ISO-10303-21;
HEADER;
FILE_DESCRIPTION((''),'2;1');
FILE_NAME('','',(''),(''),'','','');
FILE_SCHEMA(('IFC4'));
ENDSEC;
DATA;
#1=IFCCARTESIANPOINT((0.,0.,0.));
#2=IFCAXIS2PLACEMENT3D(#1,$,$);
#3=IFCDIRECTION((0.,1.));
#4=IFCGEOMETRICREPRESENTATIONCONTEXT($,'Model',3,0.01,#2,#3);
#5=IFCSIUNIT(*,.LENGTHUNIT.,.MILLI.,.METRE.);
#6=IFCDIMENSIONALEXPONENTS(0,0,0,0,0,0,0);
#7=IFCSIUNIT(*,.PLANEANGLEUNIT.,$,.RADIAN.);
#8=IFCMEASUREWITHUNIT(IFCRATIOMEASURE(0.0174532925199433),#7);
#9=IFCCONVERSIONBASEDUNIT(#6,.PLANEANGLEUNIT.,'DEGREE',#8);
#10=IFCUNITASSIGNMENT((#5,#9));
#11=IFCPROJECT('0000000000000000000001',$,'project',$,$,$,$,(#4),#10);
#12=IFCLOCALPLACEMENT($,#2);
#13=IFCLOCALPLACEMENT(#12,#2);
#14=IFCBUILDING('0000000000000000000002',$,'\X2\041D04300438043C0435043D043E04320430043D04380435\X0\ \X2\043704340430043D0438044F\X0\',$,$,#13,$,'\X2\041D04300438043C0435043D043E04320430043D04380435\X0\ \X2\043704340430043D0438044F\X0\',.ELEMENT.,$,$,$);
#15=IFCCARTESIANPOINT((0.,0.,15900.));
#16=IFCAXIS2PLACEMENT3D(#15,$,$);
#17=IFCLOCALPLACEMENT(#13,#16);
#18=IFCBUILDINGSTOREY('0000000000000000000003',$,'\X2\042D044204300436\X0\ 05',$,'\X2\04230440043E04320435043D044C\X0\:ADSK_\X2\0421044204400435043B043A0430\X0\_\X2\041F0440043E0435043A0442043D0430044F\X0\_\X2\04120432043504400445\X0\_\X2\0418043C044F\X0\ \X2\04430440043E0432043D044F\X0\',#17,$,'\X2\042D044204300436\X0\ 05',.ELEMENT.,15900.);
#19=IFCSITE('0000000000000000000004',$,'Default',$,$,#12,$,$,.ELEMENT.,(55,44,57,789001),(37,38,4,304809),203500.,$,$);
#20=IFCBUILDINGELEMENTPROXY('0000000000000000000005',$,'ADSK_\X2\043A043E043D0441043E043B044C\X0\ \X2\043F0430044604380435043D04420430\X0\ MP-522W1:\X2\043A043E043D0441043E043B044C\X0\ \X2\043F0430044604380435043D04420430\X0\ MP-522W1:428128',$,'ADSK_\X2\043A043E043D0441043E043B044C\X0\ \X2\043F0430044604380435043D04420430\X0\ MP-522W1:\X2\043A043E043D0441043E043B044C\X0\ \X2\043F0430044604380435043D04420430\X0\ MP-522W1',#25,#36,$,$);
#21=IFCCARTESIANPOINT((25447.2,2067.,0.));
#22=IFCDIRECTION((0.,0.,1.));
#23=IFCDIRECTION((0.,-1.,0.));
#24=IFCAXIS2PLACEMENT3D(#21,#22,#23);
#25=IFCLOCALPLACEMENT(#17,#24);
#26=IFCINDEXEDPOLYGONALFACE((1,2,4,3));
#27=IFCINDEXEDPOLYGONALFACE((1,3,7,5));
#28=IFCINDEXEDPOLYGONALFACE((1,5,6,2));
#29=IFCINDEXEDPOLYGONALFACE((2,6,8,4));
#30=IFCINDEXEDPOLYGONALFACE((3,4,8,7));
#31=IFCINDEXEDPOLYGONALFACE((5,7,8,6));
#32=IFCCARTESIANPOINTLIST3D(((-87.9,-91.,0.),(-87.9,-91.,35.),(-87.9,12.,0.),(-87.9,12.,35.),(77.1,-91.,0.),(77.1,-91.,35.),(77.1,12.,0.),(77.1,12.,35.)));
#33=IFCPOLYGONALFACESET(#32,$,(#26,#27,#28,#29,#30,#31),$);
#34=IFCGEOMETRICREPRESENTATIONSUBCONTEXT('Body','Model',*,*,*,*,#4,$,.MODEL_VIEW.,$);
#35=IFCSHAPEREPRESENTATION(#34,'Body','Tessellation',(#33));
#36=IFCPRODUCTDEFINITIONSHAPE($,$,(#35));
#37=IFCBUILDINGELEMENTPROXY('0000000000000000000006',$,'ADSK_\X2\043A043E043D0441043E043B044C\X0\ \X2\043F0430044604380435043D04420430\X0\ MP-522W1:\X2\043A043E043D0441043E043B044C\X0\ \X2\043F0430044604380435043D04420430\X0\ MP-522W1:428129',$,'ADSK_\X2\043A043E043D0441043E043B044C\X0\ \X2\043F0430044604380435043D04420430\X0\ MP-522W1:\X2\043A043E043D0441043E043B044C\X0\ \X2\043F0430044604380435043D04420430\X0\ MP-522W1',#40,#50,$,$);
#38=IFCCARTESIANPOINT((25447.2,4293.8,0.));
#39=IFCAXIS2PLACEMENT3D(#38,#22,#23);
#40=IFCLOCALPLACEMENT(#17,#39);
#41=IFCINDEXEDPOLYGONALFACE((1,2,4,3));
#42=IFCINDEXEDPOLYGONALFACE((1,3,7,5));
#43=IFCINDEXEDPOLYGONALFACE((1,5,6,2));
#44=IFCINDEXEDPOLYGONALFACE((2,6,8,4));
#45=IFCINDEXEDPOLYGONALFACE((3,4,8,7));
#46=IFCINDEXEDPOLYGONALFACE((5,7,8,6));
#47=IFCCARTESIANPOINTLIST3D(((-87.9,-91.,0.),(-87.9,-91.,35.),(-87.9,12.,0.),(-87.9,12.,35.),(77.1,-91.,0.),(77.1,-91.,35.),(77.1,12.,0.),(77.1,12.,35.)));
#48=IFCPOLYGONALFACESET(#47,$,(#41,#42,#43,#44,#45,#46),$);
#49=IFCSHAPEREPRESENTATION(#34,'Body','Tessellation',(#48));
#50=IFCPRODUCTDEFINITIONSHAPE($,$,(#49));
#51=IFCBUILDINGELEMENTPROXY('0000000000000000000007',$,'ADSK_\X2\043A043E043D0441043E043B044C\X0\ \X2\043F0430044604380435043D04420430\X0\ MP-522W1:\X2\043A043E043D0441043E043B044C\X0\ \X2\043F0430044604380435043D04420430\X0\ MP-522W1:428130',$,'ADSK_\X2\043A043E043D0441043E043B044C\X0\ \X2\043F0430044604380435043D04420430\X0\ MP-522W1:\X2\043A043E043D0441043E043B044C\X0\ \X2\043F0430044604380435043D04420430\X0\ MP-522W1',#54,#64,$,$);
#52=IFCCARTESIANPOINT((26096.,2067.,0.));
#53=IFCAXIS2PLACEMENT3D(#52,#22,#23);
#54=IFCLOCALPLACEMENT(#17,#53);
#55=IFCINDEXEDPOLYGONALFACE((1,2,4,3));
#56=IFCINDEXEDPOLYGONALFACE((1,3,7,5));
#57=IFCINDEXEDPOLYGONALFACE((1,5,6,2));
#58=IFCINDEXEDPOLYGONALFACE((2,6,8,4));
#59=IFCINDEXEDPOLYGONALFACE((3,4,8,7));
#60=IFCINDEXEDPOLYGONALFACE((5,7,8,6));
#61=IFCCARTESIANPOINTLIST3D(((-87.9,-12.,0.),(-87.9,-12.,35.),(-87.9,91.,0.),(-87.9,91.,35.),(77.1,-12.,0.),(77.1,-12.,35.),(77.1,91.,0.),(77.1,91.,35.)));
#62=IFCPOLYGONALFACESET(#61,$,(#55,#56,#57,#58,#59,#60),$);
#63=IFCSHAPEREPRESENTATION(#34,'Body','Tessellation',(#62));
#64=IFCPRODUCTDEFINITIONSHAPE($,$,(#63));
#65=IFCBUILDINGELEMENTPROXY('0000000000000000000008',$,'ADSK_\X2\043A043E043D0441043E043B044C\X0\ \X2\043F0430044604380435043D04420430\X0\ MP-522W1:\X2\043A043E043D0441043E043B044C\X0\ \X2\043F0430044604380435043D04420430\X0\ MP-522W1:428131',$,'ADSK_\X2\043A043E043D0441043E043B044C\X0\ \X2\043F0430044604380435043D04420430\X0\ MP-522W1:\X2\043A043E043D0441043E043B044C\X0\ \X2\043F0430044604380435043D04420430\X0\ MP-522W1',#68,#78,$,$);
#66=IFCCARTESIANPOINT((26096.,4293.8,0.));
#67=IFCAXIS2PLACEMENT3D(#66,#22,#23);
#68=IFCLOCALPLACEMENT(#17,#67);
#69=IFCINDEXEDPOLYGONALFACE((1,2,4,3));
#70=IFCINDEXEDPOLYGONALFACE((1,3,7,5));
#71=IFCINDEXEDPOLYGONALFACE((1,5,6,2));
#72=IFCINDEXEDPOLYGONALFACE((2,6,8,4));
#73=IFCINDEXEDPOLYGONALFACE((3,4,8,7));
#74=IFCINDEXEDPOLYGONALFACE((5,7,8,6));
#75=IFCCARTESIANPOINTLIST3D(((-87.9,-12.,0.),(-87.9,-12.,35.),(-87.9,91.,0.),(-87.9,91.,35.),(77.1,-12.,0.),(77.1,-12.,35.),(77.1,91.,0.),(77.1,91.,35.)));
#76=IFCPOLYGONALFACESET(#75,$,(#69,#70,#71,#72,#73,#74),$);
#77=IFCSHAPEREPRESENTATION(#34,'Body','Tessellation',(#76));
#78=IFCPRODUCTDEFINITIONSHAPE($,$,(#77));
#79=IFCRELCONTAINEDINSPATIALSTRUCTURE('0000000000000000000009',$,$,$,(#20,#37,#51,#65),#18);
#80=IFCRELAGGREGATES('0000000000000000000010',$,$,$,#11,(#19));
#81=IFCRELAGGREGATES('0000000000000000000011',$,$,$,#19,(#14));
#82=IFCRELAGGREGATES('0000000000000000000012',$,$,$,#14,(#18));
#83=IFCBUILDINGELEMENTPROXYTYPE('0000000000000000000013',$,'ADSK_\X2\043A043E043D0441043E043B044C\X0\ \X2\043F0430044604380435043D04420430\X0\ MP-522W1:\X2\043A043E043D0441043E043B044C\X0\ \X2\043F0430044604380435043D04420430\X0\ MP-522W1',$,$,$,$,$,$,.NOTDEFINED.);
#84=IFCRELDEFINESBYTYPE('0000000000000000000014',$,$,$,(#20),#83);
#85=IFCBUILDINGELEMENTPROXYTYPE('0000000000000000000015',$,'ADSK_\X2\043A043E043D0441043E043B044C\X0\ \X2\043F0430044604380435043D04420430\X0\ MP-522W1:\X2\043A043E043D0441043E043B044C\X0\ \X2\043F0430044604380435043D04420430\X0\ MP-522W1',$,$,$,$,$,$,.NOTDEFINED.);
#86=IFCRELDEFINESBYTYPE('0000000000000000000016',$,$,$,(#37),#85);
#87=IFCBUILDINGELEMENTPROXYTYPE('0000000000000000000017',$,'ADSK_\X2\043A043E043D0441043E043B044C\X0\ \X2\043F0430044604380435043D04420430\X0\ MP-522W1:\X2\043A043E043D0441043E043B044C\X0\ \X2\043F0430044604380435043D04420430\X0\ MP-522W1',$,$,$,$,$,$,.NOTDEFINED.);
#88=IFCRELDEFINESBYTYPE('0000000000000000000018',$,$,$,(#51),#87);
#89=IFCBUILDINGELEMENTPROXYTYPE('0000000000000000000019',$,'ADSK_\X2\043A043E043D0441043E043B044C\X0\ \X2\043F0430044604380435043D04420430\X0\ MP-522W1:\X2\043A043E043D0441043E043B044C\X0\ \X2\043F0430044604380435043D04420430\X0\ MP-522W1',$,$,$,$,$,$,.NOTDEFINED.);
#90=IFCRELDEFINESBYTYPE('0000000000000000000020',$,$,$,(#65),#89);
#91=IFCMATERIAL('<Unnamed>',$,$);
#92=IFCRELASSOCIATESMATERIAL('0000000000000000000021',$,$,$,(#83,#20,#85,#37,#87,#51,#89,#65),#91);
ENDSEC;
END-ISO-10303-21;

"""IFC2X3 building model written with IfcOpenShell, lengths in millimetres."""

from ifc_helpers import new_model, entity, si_unit, converted_unit, direction, frame, origin, origin_2d_with_axis, place, context, subcontext, project, spatial, rectangle, extrude, source, transform, mapped, material, type_object, type_shapes, element, save


model = new_model("IFC2X3")

# Units and contexts
model_context = context("Model", 3, precision=0.01, world=origin(), true_north=direction((0.0, 1.0)))
body_context = subcontext(model_context, "Body", "Model", "MODEL_VIEW")
ifc_project = project(units=[si_unit("LENGTHUNIT", "METRE", prefix="MILLI"), converted_unit("PLANEANGLEUNIT", "DEGREE", entity("IfcRatioMeasure", 0.0174532925199433), si_unit("PLANEANGLEUNIT", "RADIAN"), dimensions=[0, 0, 0, 0, 0, 0, 0])], contexts=[model_context])

# Site, building, storey
site_placement = place(None, origin())
site = spatial("IfcSite", under=ifc_project, at=site_placement, Name="Default", CompositionType="ELEMENT", RefLatitude=(55, 44, 57, 789001), RefLongitude=(37, 38, 4, 304809), RefElevation=203500.0)
building_placement = place(site_placement, origin())
building = spatial("IfcBuilding", under=site, at=building_placement, Name="Наименование здания", LongName="Наименование здания", CompositionType="ELEMENT")
storey_placement = place(building_placement, frame((0.0, 0.0, 15900.0)))
storey = spatial("IfcBuildingStorey", under=building, at=storey_placement, Name="Этаж 05", ObjectType="Уровень:ADSK_Стрелка_Проектная_Вверх_Имя уровня", LongName="Этаж 05", CompositionType="ELEMENT", Elevation=15900.0)

# Building element proxies
ifc_material_1 = material(Name="<Unnamed>")
building_element_proxy_type_1 = type_object("IfcBuildingElementProxyType", Name="ADSK_консоль пациента MP-522W1:консоль пациента MP-522W1", PredefinedType="NOTDEFINED", material=ifc_material_1)
shared_shape_1 = source(origin(), body_context, "Body", "SweptSolid", [
    extrude(rectangle(XDim=165.0, YDim=103.0, at=origin_2d_with_axis()), frame((-5.4, -39.5, 0.0), z_axis=(0.0, 0.0, 1.0), x_axis=(-1.0, 0.0, 0.0)), (0.0, 0.0, 1.0), 35.0),
])
type_shapes(building_element_proxy_type_1, [shared_shape_1])
proxy_1_placement = place(storey_placement, frame((25447.2, 2067.0, 0.0), z_axis=(0.0, 0.0, 1.0), x_axis=(0.0, -1.0, 0.0)))
element("IfcBuildingElementProxy", 1, at=proxy_1_placement, inside=storey, type_object=building_element_proxy_type_1, material=ifc_material_1, Name="ADSK_консоль пациента MP-522W1:консоль пациента MP-522W1:428128", ObjectType="ADSK_консоль пациента MP-522W1:консоль пациента MP-522W1", context=body_context, shape_type="MappedRepresentation", body=[
    mapped(shared_shape_1, transform((0.0, 0.0, 0.0), scale=1.0)),
])
building_element_proxy_type_2 = type_object("IfcBuildingElementProxyType", Name="ADSK_консоль пациента MP-522W1:консоль пациента MP-522W1", PredefinedType="NOTDEFINED", material=ifc_material_1)
type_shapes(building_element_proxy_type_2, [shared_shape_1])
proxy_2_placement = place(storey_placement, frame((25447.2, 4293.8, 0.0), z_axis=(0.0, 0.0, 1.0), x_axis=(0.0, -1.0, 0.0)))
element("IfcBuildingElementProxy", 2, at=proxy_2_placement, inside=storey, type_object=building_element_proxy_type_2, material=ifc_material_1, Name="ADSK_консоль пациента MP-522W1:консоль пациента MP-522W1:428129", ObjectType="ADSK_консоль пациента MP-522W1:консоль пациента MP-522W1", context=body_context, shape_type="MappedRepresentation", body=[
    mapped(shared_shape_1, transform((0.0, 0.0, 0.0), scale=1.0)),
])
building_element_proxy_type_3 = type_object("IfcBuildingElementProxyType", Name="ADSK_консоль пациента MP-522W1:консоль пациента MP-522W1", PredefinedType="NOTDEFINED", material=ifc_material_1)
shared_shape_2 = source(origin(), body_context, "Body", "SweptSolid", [
    extrude(rectangle(XDim=103.0, YDim=165.0, at=origin_2d_with_axis()), frame((-5.4, 39.5, 0.0), z_axis=(0.0, 0.0, 1.0), x_axis=(0.0, 1.0, 0.0)), (0.0, 0.0, 1.0), 35.0),
])
type_shapes(building_element_proxy_type_3, [shared_shape_2])
proxy_3_placement = place(storey_placement, frame((26096.0, 2067.0, 0.0), z_axis=(0.0, 0.0, 1.0), x_axis=(0.0, -1.0, 0.0)))
element("IfcBuildingElementProxy", 3, at=proxy_3_placement, inside=storey, type_object=building_element_proxy_type_3, material=ifc_material_1, Name="ADSK_консоль пациента MP-522W1:консоль пациента MP-522W1:428130", ObjectType="ADSK_консоль пациента MP-522W1:консоль пациента MP-522W1", context=body_context, shape_type="MappedRepresentation", body=[
    mapped(shared_shape_2, transform((0.0, 0.0, 0.0), scale=1.0)),
])
building_element_proxy_type_4 = type_object("IfcBuildingElementProxyType", Name="ADSK_консоль пациента MP-522W1:консоль пациента MP-522W1", PredefinedType="NOTDEFINED", material=ifc_material_1)
type_shapes(building_element_proxy_type_4, [shared_shape_2])
proxy_4_placement = place(storey_placement, frame((26096.0, 4293.8, 0.0), z_axis=(0.0, 0.0, 1.0), x_axis=(0.0, -1.0, 0.0)))
element("IfcBuildingElementProxy", 4, at=proxy_4_placement, inside=storey, type_object=building_element_proxy_type_4, material=ifc_material_1, Name="ADSK_консоль пациента MP-522W1:консоль пациента MP-522W1:428131", ObjectType="ADSK_консоль пациента MP-522W1:консоль пациента MP-522W1", context=body_context, shape_type="MappedRepresentation", body=[
    mapped(shared_shape_2, transform((0.0, 0.0, 0.0), scale=1.0)),
])

save(model, "model.ifc")
